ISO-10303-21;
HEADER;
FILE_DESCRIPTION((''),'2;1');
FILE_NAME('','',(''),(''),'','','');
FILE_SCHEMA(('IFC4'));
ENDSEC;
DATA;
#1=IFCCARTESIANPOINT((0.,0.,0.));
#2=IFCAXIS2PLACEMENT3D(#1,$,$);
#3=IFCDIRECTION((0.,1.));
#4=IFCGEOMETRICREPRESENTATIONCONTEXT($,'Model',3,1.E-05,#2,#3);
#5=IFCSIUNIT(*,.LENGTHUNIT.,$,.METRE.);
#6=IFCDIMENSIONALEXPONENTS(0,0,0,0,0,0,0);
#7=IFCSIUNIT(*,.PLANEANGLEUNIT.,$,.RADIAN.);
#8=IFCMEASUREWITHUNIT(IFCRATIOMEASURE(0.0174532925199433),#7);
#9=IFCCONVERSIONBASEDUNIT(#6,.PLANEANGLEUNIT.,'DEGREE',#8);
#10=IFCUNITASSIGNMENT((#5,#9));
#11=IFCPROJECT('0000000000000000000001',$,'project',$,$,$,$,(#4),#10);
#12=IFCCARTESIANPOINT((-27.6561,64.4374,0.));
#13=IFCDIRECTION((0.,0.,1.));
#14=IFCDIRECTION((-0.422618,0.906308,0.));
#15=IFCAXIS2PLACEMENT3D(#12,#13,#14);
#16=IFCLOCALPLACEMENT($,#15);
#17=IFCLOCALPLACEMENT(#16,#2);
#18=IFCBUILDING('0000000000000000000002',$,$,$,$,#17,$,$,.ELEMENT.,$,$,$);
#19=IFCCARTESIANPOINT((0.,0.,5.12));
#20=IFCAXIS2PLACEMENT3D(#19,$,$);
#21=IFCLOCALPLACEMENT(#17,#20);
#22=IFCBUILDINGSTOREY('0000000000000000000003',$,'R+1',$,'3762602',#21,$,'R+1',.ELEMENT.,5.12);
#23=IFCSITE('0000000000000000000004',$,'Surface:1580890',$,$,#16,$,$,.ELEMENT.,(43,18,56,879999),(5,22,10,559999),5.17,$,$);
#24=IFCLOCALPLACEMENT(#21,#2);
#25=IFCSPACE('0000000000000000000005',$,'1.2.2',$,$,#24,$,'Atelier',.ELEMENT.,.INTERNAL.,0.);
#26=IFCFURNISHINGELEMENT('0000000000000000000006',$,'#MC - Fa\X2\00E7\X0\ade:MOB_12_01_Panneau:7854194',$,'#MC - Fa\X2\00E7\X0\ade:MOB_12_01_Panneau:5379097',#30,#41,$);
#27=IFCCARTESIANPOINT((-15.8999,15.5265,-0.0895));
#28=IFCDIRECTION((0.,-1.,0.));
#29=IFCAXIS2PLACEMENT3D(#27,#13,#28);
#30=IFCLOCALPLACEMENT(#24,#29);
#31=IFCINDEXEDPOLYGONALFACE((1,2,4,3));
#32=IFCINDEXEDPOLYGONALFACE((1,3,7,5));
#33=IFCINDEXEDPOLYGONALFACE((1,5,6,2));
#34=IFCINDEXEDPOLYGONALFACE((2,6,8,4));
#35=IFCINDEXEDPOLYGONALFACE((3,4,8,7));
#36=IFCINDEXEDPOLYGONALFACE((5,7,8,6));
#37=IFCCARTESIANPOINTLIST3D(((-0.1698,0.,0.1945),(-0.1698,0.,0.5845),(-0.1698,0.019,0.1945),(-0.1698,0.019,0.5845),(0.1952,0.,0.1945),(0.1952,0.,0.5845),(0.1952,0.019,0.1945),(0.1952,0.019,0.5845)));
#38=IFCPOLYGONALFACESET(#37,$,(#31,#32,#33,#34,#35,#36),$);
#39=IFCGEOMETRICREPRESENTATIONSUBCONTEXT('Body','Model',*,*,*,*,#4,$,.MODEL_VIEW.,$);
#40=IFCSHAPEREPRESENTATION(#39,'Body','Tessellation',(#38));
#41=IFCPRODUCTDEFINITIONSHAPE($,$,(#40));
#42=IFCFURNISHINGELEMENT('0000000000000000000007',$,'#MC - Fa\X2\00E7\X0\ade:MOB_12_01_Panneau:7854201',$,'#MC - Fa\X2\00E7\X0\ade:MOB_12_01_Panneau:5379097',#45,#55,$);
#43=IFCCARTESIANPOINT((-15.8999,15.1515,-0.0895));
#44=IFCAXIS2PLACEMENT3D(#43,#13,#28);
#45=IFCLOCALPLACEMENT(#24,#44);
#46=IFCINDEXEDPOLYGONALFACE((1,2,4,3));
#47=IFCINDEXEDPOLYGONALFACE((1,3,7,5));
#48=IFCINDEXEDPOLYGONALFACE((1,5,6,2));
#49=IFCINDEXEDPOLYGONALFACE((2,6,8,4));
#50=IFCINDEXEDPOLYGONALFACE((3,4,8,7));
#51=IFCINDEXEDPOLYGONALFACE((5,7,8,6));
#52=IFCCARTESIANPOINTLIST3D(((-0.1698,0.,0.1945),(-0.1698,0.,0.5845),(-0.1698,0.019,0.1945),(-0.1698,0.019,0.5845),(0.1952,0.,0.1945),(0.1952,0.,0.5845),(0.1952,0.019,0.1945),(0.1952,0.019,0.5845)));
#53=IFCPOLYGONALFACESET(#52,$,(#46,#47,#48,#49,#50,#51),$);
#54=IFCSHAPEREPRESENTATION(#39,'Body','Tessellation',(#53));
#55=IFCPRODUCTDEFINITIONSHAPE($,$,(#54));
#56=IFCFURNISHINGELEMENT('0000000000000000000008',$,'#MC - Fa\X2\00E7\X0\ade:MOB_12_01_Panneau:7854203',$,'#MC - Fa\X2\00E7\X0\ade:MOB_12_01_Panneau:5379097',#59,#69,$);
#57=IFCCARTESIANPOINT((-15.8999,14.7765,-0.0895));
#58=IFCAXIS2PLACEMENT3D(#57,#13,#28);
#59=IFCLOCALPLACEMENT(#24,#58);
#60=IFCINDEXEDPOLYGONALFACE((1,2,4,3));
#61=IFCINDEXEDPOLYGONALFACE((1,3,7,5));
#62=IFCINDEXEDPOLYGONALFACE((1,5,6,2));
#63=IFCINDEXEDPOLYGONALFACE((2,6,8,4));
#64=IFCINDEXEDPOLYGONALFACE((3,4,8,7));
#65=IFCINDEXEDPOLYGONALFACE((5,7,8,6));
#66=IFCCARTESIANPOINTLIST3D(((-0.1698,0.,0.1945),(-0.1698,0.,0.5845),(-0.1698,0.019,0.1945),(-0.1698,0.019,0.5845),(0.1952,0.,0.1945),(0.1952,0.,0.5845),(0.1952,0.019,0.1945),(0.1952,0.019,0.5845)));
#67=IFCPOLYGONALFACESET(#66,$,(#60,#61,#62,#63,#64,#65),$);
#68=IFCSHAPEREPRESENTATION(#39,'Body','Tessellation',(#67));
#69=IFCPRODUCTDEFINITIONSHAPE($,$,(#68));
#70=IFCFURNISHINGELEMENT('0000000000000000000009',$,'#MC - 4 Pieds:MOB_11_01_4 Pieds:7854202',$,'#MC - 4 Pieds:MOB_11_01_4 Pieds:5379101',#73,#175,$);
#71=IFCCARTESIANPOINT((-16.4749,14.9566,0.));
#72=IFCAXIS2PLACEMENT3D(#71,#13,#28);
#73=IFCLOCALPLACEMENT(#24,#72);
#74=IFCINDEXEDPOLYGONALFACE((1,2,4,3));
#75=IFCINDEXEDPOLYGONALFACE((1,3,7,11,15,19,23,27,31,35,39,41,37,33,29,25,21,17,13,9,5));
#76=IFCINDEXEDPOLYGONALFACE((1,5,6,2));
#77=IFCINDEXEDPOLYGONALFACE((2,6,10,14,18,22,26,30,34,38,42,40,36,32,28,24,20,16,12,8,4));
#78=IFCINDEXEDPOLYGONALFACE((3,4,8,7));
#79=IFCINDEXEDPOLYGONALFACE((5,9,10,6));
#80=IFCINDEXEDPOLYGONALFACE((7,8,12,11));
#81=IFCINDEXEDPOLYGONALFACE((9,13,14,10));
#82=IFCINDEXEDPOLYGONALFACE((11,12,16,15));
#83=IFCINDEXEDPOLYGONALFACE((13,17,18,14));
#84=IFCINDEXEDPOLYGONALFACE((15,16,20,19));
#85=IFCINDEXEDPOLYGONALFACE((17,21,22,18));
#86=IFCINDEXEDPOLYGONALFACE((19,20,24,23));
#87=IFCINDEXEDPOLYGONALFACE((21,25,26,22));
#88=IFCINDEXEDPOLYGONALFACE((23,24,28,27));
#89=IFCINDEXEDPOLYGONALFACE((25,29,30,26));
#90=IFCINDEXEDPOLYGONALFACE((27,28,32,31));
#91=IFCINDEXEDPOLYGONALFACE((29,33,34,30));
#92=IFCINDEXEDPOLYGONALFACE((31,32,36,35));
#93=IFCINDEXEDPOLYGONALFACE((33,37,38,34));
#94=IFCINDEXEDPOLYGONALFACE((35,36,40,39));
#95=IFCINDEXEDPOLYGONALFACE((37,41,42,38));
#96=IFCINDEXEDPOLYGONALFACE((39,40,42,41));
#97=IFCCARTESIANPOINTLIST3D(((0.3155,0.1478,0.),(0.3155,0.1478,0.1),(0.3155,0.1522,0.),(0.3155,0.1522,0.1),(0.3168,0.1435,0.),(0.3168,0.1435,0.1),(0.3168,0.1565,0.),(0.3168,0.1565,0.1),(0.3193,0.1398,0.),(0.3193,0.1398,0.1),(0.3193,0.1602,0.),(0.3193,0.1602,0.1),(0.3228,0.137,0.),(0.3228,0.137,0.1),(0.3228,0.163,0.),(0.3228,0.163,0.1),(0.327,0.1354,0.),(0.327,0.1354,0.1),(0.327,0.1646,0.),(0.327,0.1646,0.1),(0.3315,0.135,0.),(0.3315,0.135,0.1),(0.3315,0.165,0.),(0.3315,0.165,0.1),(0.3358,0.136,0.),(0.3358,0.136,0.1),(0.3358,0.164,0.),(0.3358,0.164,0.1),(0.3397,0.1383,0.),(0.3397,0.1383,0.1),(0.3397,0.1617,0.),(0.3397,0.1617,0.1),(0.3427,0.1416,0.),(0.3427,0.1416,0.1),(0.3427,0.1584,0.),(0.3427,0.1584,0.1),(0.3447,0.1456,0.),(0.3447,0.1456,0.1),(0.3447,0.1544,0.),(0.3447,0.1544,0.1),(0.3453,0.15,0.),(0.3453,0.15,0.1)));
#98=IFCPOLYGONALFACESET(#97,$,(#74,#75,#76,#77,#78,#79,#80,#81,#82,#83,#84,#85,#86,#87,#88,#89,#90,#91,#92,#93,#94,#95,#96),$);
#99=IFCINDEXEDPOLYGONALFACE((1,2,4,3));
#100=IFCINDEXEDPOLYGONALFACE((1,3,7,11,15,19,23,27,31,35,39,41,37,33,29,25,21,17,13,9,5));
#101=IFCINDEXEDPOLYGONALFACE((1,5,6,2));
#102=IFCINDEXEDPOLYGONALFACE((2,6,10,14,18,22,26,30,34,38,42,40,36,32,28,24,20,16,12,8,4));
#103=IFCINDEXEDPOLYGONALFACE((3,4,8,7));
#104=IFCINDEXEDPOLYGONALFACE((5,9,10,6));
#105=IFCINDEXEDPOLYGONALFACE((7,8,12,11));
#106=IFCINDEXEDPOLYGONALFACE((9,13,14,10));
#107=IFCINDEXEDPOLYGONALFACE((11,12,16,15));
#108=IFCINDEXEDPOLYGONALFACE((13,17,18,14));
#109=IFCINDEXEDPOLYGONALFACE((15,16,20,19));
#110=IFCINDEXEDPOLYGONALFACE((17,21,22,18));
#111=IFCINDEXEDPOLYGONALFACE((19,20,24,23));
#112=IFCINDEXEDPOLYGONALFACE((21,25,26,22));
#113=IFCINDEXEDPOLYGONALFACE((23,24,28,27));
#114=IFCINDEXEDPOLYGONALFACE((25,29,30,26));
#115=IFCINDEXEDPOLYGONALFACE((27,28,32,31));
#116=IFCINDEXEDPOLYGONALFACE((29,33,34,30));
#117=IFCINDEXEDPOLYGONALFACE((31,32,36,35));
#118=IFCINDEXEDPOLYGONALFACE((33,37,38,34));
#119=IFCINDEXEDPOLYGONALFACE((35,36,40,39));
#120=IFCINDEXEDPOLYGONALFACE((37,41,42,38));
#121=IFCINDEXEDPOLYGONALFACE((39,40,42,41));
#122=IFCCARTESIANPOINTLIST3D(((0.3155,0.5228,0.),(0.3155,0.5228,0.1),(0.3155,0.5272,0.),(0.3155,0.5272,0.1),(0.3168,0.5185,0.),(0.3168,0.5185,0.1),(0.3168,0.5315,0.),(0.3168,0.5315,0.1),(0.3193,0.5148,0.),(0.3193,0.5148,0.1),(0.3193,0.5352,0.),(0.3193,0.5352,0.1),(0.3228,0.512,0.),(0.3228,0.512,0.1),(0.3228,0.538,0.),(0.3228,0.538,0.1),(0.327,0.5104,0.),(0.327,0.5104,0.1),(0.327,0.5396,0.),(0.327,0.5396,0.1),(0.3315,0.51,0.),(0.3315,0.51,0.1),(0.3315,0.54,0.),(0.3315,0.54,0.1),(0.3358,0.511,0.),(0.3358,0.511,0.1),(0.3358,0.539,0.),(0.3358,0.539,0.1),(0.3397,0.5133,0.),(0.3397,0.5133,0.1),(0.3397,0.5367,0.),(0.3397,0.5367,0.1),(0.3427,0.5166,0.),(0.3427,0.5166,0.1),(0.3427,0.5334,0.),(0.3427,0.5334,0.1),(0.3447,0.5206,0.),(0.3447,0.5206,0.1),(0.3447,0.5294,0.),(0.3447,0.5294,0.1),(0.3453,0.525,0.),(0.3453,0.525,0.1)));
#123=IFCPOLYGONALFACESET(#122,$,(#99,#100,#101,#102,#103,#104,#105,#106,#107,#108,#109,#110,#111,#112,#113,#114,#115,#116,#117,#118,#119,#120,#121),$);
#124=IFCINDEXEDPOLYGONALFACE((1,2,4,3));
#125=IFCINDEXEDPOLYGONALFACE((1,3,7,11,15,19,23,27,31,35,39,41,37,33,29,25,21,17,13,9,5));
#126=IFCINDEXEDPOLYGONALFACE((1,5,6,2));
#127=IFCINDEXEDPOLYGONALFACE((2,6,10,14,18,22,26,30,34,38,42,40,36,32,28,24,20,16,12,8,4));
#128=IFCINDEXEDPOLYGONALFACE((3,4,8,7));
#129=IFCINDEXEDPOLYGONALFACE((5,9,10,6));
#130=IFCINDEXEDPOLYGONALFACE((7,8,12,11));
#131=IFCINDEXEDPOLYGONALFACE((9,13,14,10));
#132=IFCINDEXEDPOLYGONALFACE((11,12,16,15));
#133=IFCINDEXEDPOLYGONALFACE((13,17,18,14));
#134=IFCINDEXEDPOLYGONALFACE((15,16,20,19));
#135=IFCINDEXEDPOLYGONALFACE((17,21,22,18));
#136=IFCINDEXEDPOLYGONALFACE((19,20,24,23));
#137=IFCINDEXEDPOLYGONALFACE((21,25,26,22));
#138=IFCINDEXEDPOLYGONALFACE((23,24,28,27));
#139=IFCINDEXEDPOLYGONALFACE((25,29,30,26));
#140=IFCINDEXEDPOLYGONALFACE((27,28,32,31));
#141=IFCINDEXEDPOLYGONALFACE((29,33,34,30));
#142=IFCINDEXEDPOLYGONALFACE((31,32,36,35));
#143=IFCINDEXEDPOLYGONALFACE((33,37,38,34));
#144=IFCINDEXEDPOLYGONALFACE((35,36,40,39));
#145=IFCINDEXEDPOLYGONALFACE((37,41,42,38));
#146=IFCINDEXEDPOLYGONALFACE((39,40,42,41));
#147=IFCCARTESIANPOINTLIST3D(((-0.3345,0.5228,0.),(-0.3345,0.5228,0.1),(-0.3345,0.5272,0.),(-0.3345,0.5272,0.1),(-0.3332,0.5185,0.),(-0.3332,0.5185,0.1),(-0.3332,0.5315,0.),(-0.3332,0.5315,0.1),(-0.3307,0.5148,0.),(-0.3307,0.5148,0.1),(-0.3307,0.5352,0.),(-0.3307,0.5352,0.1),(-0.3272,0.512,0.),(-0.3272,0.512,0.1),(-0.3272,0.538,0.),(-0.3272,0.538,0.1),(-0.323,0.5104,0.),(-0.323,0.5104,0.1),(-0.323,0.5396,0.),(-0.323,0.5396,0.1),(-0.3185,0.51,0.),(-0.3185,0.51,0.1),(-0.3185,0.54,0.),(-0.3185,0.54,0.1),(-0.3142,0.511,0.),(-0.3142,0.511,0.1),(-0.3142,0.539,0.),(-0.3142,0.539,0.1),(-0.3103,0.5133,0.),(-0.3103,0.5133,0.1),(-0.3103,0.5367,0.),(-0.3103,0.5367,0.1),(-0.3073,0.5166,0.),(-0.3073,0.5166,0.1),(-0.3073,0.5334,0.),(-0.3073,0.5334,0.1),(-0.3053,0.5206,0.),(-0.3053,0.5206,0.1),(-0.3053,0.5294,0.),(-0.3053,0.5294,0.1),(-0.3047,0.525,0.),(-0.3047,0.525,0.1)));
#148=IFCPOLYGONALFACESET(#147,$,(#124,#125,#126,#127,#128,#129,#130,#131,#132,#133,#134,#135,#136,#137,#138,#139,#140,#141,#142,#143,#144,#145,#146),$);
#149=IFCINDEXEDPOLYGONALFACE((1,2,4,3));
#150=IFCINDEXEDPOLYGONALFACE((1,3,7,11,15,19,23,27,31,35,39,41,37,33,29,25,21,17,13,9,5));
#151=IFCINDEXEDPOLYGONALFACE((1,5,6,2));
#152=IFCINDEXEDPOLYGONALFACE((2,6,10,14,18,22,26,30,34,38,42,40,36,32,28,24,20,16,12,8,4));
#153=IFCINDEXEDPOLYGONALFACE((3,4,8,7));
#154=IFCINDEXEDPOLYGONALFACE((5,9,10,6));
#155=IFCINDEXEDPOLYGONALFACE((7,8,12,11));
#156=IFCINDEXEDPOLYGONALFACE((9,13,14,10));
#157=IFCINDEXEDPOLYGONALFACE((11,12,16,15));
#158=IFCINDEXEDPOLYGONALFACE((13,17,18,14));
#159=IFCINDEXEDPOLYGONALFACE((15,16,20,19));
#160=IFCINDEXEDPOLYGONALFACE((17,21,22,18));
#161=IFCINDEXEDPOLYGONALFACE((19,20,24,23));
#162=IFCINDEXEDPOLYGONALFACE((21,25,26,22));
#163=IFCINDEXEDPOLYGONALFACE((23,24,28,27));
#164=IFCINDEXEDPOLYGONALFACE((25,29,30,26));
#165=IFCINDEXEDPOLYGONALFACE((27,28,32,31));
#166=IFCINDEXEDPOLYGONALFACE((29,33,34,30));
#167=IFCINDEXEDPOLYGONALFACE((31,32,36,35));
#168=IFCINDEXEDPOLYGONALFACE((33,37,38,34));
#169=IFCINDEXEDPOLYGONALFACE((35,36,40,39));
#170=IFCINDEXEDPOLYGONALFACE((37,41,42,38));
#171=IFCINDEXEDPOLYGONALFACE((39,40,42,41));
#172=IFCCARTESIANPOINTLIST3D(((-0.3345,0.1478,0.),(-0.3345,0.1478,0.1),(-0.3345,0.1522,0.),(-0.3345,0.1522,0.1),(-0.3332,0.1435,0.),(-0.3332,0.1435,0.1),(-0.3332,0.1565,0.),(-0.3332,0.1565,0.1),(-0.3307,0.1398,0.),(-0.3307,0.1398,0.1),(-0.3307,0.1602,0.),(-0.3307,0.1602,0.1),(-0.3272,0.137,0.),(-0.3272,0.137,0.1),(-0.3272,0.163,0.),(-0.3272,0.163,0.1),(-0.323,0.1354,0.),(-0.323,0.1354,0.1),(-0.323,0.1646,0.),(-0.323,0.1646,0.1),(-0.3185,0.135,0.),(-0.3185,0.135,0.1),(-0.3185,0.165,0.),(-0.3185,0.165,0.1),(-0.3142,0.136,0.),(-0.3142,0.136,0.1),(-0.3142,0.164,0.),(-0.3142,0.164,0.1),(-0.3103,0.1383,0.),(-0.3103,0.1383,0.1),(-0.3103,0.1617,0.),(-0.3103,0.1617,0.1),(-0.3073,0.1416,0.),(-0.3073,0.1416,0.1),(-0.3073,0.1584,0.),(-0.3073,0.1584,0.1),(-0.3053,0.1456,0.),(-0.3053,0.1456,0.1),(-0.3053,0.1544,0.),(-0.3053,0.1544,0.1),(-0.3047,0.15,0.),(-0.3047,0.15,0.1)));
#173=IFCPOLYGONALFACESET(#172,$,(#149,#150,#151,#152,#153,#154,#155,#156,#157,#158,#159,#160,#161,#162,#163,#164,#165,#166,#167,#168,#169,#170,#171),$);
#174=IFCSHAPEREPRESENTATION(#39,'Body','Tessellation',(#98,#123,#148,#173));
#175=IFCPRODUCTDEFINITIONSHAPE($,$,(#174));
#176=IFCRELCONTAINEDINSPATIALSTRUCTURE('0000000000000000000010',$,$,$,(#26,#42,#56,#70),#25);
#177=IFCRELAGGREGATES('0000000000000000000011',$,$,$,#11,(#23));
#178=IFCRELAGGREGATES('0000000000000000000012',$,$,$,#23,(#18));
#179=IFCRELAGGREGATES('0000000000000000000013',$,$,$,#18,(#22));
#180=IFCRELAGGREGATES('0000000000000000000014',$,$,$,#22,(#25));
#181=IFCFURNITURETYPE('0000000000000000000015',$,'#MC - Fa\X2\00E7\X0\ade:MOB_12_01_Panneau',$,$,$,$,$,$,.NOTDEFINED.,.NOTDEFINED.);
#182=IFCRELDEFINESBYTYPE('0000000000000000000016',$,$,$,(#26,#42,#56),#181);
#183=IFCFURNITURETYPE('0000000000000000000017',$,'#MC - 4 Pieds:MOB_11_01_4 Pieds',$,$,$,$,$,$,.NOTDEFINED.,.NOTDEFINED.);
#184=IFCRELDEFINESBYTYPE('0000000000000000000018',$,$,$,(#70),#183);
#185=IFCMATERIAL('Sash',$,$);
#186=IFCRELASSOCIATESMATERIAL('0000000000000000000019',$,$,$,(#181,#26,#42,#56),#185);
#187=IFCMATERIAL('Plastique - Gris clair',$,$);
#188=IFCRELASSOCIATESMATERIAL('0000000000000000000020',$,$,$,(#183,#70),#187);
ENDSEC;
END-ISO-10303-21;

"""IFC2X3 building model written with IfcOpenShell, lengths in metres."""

from ifc_helpers import new_model, entity, si_unit, converted_unit, direction, frame, frame_2d, origin, origin_2d_with_axis, place, context, subcontext, project, spatial, rectangle, circle, extrude, source, transform, mapped, material, type_object, type_shapes, element, save


model = new_model("IFC2X3")

# Units and contexts
model_context = context("Model", 3, precision=1e-05, world=origin(), true_north=direction((0.0, 1.0)))
body_context = subcontext(model_context, "Body", "Model", "MODEL_VIEW")
ifc_project = project(units=[si_unit("LENGTHUNIT", "METRE"), converted_unit("PLANEANGLEUNIT", "DEGREE", entity("IfcRatioMeasure", 0.0174532925199433), si_unit("PLANEANGLEUNIT", "RADIAN"), dimensions=[0, 0, 0, 0, 0, 0, 0])], contexts=[model_context])

# Site, building, storey
site_placement = place(None, frame((-27.6561, 64.4374, 0.0), z_axis=(0.0, 0.0, 1.0), x_axis=(-0.422618, 0.906308, 0.0)))
site = spatial("IfcSite", under=ifc_project, at=site_placement, Name="Surface:1580890", CompositionType="ELEMENT", RefLatitude=(43, 18, 56, 879999), RefLongitude=(5, 22, 10, 559999), RefElevation=5.17)
building_placement = place(site_placement, origin())
building = spatial("IfcBuilding", under=site, at=building_placement, CompositionType="ELEMENT")
storey_placement = place(building_placement, frame((0.0, 0.0, 5.12)))
storey = spatial("IfcBuildingStorey", under=building, at=storey_placement, Name="R+1", ObjectType="3762602", LongName="R+1", CompositionType="ELEMENT", Elevation=5.12)

# Shared definitions
space_placement = place(storey_placement, origin())
space = spatial("IfcSpace", under=storey, at=space_placement, Name="1.2.2", LongName="Atelier", CompositionType="ELEMENT", InteriorOrExteriorSpace="INTERNAL", ElevationWithFlooring=0.0)

# Furnishing elements
ifc_material_1 = material(Name="Sash")
furniture_type_1 = type_object("IfcFurnitureType", Name="#MC - Façade:MOB_12_01_Panneau", material=ifc_material_1)
shared_shape_1 = source(origin(), body_context, "Body", "SweptSolid", [
    extrude(rectangle(XDim=0.019, YDim=0.365, at=origin_2d_with_axis()), frame((0.0127, 0.0095, 0.1945), z_axis=(0.0, 0.0, 1.0), x_axis=(0.0, 1.0, 0.0)), (0.0, 0.0, 1.0), 0.39),
])
type_shapes(furniture_type_1, [shared_shape_1])
for number, where, z_axis, x_axis, name in (
    (1, (-15.8999, 15.5265, -0.0895), (0.0, 0.0, 1.0), (0.0, -1.0, 0.0), "#MC - Façade:MOB_12_01_Panneau:7854194"),
    (2, (-15.8999, 15.1515, -0.0895), (0.0, 0.0, 1.0), (0.0, -1.0, 0.0), "#MC - Façade:MOB_12_01_Panneau:7854201"),
    (3, (-15.8999, 14.7765, -0.0895), (0.0, 0.0, 1.0), (0.0, -1.0, 0.0), "#MC - Façade:MOB_12_01_Panneau:7854203"),
):
    element("IfcFurnishingElement", number, at=place(space_placement, frame(where, z_axis=z_axis, x_axis=x_axis)), inside=space, type_object=furniture_type_1, material=ifc_material_1, Name=name, ObjectType="#MC - Façade:MOB_12_01_Panneau:5379097", context=body_context, shape_type="MappedRepresentation", body=[
        mapped(shared_shape_1, transform((0.0, 0.0, 0.0), scale=1.0)),
    ])
ifc_material_2 = material(Name="Plastique - Gris clair")
furniture_type_2 = type_object("IfcFurnitureType", Name="#MC - 4 Pieds:MOB_11_01_4 Pieds", material=ifc_material_2)
shared_shape_2 = source(origin(), body_context, "Body", "SweptSolid", [
    extrude(circle(Radius=0.015, at=frame_2d((0.0, 0.0), x_axis=(1.0, 0.0))), frame((0.3303, 0.15, 0.0)), (0.0, 0.0, 1.0), 0.1),
    extrude(circle(Radius=0.015, at=frame_2d((0.0, 0.0), x_axis=(1.0, 0.0))), frame((0.3303, 0.525, 0.0)), (0.0, 0.0, 1.0), 0.1),
    extrude(circle(Radius=0.015, at=origin_2d_with_axis()), frame((-0.3197, 0.525, 0.0)), (0.0, 0.0, 1.0), 0.1),
    extrude(circle(Radius=0.015, at=frame_2d((0.0, 0.0), x_axis=(1.0, 0.0))), frame((-0.3197, 0.15, 0.0)), (0.0, 0.0, 1.0), 0.1),
])
type_shapes(furniture_type_2, [shared_shape_2])
furnishing_1_placement = place(space_placement, frame((-16.4749, 14.9566, 0.0), z_axis=(0.0, 0.0, 1.0), x_axis=(0.0, -1.0, 0.0)))
element("IfcFurnishingElement", 4, at=furnishing_1_placement, inside=space, type_object=furniture_type_2, material=ifc_material_2, Name="#MC - 4 Pieds:MOB_11_01_4 Pieds:7854202", ObjectType="#MC - 4 Pieds:MOB_11_01_4 Pieds:5379101", context=body_context, shape_type="MappedRepresentation", body=[
    mapped(shared_shape_2, transform((0.0, 0.0, 0.0), scale=1.0)),
])

save(model, "model.ifc")
